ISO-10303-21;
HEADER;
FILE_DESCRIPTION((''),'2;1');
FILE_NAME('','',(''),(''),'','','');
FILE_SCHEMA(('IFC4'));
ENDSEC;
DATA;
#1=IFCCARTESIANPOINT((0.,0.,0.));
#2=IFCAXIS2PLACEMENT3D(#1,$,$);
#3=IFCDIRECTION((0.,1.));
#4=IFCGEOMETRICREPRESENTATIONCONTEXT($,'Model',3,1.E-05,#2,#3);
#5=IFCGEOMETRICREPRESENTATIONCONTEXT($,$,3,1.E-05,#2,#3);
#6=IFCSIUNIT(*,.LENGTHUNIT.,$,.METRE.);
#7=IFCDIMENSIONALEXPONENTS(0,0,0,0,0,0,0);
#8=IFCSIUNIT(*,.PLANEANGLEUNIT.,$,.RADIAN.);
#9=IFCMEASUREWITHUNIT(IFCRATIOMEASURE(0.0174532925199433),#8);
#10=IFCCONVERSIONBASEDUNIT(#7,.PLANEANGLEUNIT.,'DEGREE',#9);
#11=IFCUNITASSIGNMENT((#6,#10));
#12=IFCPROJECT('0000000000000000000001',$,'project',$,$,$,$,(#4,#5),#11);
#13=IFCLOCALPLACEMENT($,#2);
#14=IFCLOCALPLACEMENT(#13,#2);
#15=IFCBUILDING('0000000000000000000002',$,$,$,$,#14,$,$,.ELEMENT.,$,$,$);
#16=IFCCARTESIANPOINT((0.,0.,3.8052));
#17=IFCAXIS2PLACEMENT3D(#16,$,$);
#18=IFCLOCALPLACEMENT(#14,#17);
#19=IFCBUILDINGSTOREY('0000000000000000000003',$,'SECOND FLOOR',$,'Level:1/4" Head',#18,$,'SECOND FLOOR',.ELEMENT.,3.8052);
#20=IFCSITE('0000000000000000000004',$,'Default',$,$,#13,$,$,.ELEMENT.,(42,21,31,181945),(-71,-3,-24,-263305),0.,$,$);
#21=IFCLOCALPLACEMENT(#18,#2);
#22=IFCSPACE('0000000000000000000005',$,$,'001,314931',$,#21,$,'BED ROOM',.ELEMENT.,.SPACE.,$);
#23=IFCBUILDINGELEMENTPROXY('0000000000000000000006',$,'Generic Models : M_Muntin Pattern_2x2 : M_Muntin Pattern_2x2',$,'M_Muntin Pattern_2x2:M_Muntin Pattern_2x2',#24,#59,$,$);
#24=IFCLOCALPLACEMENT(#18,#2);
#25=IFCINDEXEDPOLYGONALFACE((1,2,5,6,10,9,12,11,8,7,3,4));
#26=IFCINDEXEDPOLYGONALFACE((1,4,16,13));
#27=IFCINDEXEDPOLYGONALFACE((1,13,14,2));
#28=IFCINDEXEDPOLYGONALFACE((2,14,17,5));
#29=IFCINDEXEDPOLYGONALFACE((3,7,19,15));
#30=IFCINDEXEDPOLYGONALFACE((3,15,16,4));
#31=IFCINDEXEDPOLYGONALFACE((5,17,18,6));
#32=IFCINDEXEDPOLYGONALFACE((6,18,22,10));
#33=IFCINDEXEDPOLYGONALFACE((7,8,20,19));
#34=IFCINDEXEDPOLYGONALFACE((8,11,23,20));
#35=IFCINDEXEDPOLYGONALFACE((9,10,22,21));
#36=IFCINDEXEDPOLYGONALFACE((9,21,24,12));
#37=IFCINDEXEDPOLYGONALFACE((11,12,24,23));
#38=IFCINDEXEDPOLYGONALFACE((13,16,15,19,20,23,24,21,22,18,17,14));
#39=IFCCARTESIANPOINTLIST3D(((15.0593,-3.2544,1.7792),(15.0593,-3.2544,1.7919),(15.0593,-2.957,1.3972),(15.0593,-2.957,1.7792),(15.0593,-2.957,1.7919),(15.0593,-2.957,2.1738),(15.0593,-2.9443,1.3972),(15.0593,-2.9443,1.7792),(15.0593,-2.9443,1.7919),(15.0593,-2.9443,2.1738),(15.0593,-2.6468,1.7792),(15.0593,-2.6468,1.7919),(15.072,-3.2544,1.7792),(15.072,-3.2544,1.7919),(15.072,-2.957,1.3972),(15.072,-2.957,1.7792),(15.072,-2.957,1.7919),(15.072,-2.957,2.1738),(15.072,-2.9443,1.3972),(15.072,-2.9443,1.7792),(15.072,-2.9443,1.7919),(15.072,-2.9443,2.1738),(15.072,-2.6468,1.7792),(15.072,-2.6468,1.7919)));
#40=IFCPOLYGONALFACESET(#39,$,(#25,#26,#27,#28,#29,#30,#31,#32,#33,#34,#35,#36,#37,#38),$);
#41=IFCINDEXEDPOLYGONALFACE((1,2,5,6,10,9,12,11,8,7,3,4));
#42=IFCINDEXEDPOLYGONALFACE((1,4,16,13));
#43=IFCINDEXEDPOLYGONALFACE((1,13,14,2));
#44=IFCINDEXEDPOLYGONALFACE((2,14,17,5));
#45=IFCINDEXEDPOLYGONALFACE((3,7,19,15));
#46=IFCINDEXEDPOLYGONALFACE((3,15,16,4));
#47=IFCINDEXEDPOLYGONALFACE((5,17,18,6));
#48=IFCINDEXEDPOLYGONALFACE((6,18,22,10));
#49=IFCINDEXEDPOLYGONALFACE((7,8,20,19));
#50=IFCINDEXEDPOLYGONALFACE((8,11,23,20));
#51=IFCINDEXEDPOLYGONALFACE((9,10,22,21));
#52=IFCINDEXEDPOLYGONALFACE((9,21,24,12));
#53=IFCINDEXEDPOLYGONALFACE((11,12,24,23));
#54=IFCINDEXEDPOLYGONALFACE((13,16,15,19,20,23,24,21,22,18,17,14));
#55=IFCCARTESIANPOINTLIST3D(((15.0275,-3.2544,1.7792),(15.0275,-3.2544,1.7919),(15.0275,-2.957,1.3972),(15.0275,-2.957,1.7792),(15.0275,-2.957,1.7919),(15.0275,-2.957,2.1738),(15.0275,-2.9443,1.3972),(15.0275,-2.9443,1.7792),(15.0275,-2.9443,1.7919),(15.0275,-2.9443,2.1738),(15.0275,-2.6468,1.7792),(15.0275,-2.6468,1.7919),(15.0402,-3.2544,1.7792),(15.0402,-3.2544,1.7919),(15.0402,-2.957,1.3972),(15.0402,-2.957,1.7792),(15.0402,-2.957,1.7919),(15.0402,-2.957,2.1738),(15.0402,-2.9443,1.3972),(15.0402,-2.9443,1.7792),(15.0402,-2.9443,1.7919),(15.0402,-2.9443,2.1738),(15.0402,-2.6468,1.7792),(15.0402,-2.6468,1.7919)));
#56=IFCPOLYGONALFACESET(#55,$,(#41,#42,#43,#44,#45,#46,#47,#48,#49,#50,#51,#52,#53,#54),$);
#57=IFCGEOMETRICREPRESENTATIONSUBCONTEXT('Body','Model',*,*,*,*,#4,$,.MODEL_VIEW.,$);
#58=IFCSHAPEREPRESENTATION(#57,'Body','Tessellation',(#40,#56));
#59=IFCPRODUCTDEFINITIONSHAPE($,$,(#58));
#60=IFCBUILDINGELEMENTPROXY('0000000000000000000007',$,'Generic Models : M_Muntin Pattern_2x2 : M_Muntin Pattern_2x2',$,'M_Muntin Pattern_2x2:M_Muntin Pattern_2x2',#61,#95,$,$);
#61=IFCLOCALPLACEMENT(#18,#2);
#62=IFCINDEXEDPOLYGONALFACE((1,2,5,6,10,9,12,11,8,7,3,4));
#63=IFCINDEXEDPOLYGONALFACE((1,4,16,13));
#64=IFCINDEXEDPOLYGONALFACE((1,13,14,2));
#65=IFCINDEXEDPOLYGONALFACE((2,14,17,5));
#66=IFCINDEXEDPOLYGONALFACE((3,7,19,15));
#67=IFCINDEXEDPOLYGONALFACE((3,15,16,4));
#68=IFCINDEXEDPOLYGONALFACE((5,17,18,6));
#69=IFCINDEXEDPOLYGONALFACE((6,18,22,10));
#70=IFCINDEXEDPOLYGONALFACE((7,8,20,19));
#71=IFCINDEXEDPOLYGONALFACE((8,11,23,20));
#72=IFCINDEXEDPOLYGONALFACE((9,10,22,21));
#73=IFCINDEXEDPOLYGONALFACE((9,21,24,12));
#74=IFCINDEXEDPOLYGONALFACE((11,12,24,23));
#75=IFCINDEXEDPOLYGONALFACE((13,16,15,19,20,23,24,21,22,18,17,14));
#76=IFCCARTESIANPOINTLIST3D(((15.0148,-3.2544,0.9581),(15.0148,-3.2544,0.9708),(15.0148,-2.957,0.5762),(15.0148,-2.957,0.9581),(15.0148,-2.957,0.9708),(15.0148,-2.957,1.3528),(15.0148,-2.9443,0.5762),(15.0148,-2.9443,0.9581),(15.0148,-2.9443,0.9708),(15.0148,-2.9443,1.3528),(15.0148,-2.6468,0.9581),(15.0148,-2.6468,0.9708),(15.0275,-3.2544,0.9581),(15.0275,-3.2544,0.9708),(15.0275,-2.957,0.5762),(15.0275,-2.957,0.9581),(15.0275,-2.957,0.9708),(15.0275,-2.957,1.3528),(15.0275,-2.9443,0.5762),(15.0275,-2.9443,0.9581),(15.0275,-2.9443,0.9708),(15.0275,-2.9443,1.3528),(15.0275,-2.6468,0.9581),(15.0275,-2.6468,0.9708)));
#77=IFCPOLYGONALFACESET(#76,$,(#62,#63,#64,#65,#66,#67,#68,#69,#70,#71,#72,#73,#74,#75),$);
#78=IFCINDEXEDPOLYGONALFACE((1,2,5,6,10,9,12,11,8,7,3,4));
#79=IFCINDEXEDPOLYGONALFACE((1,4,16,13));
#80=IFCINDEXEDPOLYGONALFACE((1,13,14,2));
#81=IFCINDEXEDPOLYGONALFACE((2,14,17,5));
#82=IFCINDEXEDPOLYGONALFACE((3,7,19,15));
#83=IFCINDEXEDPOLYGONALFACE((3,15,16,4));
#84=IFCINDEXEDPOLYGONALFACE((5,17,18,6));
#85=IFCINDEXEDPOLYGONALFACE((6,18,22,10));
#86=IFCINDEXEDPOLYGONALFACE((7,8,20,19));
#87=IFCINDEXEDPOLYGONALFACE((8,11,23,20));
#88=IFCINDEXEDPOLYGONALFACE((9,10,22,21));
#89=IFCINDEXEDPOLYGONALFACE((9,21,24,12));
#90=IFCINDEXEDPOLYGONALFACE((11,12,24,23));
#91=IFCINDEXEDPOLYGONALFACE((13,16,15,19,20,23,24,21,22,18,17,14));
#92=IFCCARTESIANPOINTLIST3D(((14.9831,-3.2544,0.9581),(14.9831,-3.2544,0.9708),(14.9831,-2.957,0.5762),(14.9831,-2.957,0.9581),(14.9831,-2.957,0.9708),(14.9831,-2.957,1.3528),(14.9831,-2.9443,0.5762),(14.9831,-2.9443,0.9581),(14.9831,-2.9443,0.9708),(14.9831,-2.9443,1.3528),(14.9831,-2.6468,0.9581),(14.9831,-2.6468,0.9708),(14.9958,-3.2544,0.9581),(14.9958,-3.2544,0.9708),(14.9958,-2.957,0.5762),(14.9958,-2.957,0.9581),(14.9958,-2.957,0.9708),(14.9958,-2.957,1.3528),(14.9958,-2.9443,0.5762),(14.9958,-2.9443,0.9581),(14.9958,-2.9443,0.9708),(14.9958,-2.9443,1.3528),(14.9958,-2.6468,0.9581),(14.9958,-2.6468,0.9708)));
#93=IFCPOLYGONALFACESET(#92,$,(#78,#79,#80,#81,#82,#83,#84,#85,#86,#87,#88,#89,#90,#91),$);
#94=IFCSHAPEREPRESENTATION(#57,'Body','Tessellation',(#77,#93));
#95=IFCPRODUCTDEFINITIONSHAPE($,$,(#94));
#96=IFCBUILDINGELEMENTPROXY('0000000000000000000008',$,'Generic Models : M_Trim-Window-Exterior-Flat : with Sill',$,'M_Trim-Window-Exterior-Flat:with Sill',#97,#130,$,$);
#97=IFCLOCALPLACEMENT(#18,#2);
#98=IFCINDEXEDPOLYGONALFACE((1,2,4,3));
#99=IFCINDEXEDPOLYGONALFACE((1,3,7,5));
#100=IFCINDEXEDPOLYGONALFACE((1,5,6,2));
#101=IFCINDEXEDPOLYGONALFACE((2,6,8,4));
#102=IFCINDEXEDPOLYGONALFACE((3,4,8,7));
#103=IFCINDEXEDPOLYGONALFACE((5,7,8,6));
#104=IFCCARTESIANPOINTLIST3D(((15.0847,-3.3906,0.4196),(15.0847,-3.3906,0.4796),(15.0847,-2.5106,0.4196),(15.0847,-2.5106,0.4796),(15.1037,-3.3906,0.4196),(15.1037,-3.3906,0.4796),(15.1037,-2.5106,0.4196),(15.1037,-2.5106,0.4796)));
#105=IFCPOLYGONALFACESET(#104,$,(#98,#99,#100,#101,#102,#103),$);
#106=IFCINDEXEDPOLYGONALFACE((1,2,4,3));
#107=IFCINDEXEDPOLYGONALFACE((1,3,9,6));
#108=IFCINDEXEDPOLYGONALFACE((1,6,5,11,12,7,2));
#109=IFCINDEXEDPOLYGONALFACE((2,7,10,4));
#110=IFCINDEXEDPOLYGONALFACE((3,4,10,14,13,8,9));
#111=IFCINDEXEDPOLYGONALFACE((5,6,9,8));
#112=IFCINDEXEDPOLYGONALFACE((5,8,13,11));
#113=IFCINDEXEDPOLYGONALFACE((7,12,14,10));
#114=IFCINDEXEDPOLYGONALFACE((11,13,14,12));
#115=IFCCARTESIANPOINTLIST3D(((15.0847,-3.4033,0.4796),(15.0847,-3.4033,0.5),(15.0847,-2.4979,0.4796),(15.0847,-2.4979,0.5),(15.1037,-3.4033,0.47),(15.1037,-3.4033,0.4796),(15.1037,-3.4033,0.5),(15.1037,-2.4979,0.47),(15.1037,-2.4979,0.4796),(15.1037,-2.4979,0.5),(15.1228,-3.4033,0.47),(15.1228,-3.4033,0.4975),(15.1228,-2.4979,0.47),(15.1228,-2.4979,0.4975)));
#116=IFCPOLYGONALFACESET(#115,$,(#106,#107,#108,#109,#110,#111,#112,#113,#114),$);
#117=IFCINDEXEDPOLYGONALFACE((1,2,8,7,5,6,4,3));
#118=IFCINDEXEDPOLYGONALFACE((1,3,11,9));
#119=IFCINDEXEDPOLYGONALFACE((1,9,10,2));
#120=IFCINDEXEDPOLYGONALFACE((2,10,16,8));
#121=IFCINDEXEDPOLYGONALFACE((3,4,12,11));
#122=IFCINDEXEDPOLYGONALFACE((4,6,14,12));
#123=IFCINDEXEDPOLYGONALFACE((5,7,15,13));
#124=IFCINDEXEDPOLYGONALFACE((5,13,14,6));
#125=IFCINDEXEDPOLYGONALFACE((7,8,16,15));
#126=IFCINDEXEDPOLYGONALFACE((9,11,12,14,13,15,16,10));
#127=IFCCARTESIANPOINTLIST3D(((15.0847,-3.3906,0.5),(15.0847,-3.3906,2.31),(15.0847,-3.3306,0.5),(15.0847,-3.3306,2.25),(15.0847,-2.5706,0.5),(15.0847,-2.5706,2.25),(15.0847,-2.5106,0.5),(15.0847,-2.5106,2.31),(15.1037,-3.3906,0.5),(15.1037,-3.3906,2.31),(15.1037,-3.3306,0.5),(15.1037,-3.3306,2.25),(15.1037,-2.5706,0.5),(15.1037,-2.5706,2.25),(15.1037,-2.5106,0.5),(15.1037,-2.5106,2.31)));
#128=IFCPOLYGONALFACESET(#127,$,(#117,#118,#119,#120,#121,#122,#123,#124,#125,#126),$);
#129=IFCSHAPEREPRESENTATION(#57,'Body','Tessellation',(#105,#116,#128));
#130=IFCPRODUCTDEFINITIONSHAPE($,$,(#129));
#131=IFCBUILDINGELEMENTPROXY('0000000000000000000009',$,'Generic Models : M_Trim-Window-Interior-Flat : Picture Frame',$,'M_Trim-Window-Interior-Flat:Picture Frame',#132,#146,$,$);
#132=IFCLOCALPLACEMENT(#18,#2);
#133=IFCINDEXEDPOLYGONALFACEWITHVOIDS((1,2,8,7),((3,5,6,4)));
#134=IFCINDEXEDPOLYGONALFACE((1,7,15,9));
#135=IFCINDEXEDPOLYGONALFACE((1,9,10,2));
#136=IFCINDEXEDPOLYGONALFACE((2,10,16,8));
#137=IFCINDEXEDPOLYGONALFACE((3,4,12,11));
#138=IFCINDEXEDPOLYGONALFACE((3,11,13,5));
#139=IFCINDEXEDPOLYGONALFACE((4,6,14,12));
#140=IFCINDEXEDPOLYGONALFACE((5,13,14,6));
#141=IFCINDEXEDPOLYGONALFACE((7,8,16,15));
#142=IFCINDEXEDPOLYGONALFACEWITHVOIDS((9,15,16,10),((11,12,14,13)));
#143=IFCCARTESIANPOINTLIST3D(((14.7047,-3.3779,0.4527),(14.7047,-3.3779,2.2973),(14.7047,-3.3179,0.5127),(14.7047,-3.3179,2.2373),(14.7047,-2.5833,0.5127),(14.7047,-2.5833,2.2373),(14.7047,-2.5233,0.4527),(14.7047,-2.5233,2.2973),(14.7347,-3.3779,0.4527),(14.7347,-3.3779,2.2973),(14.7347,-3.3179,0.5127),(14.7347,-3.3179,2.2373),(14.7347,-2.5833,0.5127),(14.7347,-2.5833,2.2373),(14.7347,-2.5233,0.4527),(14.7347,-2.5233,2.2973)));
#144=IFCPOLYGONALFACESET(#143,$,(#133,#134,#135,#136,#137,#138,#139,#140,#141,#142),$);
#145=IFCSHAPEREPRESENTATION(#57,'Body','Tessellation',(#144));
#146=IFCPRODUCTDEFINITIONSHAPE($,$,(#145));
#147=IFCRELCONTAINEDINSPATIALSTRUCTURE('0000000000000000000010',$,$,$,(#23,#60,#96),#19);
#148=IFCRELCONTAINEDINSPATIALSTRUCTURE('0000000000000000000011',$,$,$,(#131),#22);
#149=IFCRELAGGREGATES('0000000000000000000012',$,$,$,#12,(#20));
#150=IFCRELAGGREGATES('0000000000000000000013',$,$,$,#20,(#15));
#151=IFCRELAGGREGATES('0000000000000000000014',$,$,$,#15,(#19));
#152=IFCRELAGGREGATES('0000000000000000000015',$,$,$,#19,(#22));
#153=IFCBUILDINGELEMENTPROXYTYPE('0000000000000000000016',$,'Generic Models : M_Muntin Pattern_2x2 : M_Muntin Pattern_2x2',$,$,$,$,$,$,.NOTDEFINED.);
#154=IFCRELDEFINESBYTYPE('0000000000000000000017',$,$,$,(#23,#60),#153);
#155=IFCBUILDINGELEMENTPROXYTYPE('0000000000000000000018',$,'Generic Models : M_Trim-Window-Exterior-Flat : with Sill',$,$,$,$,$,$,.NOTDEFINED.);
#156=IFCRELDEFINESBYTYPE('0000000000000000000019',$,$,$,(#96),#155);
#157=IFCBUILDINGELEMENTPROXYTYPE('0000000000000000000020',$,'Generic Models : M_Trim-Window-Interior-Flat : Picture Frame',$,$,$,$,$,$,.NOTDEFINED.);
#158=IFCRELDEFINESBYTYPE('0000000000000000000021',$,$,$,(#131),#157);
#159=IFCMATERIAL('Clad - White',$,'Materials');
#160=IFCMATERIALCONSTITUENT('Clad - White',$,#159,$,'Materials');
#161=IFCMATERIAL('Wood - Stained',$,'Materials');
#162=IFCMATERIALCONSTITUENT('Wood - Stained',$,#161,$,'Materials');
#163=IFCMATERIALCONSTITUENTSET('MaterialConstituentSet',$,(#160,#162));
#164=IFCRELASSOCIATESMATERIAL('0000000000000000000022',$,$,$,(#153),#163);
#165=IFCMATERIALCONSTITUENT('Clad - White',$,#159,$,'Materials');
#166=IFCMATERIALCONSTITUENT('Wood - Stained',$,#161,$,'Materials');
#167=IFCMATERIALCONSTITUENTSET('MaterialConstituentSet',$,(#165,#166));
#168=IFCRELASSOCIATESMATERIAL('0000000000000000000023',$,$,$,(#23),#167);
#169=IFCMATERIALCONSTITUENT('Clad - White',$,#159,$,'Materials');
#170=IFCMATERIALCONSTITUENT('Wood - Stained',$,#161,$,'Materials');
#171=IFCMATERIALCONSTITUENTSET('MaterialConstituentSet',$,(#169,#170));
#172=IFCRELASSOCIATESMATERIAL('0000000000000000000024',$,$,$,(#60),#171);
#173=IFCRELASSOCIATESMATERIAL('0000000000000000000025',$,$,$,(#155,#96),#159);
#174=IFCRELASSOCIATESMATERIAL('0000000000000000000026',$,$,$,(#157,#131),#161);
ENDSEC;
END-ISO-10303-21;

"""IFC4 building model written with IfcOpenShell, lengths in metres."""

from ifc_helpers import new_model, entity, si_unit, converted_unit, direction, frame, frame_2d, origin, place, context, subcontext, project, spatial, polyline, rectangle, outline, extrude, source, transform, mapped, material, constituent, constituent_set, type_object, type_shapes, element, save


model = new_model("IFC4")

# Units and contexts
model_context = context("Model", 3, precision=1e-05, world=origin(), true_north=direction((0.0, 1.0)))
context_of_model = context(None, 3, precision=1e-05, world=origin(), true_north=direction((0.0, 1.0)))
body_context = subcontext(model_context, "Body", "Model", "MODEL_VIEW")
ifc_project = project(units=[si_unit("LENGTHUNIT", "METRE"), converted_unit("PLANEANGLEUNIT", "DEGREE", entity("IfcRatioMeasure", 0.0174532925199433), si_unit("PLANEANGLEUNIT", "RADIAN"), dimensions=[0, 0, 0, 0, 0, 0, 0])], contexts=[model_context, context_of_model])

# Site, building, storey
site_placement = place(None, origin())
site = spatial("IfcSite", under=ifc_project, at=site_placement, Name="Default", CompositionType="ELEMENT", RefLatitude=(42, 21, 31, 181945), RefLongitude=(-71, -3, -24, -263305), RefElevation=0.0)
building_placement = place(site_placement, origin())
building = spatial("IfcBuilding", under=site, at=building_placement, CompositionType="ELEMENT")
storey_placement = place(building_placement, frame((0.0, 0.0, 3.8052)))
storey = spatial("IfcBuildingStorey", under=building, at=storey_placement, Name="SECOND FLOOR", ObjectType="Level:1/4\" Head", LongName="SECOND FLOOR", CompositionType="ELEMENT", Elevation=3.8052)

# Shared definitions
ifc_material_1 = material(Name="Wood - Stained", Category="Materials")

# Shared definitions
ifc_material_2 = material(Name="Clad - White", Category="Materials")

# Shared definitions
space_1_placement = place(storey_placement, origin())
space_1 = spatial("IfcSpace", under=storey, at=space_1_placement, Description="001,314931", LongName="BED ROOM", CompositionType="ELEMENT", PredefinedType="SPACE")

# Building element proxies
ifc_constituent_1 = constituent(ifc_material_2, Name="Clad - White", Category="Materials")
ifc_constituent_2 = constituent(ifc_material_1, Name="Wood - Stained", Category="Materials")
ifc_constituent_set_1 = constituent_set(constituents=[ifc_constituent_1, ifc_constituent_2], Name="MaterialConstituentSet")
ifc_constituent_3 = constituent(ifc_material_2, Name="Clad - White", Category="Materials")
ifc_constituent_4 = constituent(ifc_material_1, Name="Wood - Stained", Category="Materials")
ifc_constituent_set_2 = constituent_set(constituents=[ifc_constituent_3, ifc_constituent_4], Name="MaterialConstituentSet")
building_element_proxy_type_1 = type_object("IfcBuildingElementProxyType", Name="Generic Models : M_Muntin Pattern_2x2 : M_Muntin Pattern_2x2", PredefinedType="NOTDEFINED", material=ifc_constituent_set_2)
shared_shape_1 = source(origin(), body_context, "Body", "SweptSolid", [
    extrude(outline(polyline([(0.0064, -0.0064), (0.3883, -0.0064), (0.3883, 0.0063), (0.0064, 0.0063), (0.0064, 0.3038), (-0.0063, 0.3038), (-0.0063, 0.0063), (-0.3883, 0.0063), (-0.3883, -0.0064), (-0.0063, -0.0064), (-0.0063, -0.3038), (0.0064, -0.3038), (0.0064, -0.0064)])), frame((0.0, -0.0222, 0.3883), z_axis=(0.0, 1.0, 0.0), x_axis=(0.0, 0.0, 1.0)), (0.0, 0.0, 1.0), 0.0127),
    extrude(outline(polyline([(0.0064, -0.0064), (0.3883, -0.0064), (0.3883, 0.0063), (0.0064, 0.0063), (0.0064, 0.3038), (-0.0063, 0.3038), (-0.0063, 0.0063), (-0.3883, 0.0063), (-0.3883, -0.0064), (-0.0063, -0.0064), (-0.0063, -0.3038), (0.0064, -0.3038), (0.0064, -0.0064)])), frame((0.0, 0.0095, 0.3883), z_axis=(0.0, 1.0, 0.0), x_axis=(0.0, 0.0, 1.0)), (0.0, 0.0, 1.0), 0.0127),
])
type_shapes(building_element_proxy_type_1, [shared_shape_1])
proxy_1_placement = place(storey_placement, frame((15.0498, -2.9506, 1.3972), z_axis=(0.0, 0.0, 1.0), x_axis=(0.0, 1.0, 0.0)))
element("IfcBuildingElementProxy", 1, at=proxy_1_placement, inside=storey, type_object=building_element_proxy_type_1, material=ifc_constituent_set_1, Name="Generic Models : M_Muntin Pattern_2x2 : M_Muntin Pattern_2x2", ObjectType="M_Muntin Pattern_2x2:M_Muntin Pattern_2x2", context=body_context, shape_type="MappedRepresentation", body=[
    mapped(shared_shape_1, transform((0.0, 0.0, 0.0), scale=1.0)),
])
ifc_constituent_5 = constituent(ifc_material_2, Name="Clad - White", Category="Materials")
ifc_constituent_6 = constituent(ifc_material_1, Name="Wood - Stained", Category="Materials")
ifc_constituent_set_3 = constituent_set(constituents=[ifc_constituent_5, ifc_constituent_6], Name="MaterialConstituentSet")
proxy_2_placement = place(storey_placement, frame((15.0053, -2.9506, 0.5762), z_axis=(0.0, 0.0, 1.0), x_axis=(0.0, 1.0, 0.0)))
element("IfcBuildingElementProxy", 2, at=proxy_2_placement, inside=storey, type_object=building_element_proxy_type_1, material=ifc_constituent_set_3, Name="Generic Models : M_Muntin Pattern_2x2 : M_Muntin Pattern_2x2", ObjectType="M_Muntin Pattern_2x2:M_Muntin Pattern_2x2", context=body_context, shape_type="MappedRepresentation", body=[
    mapped(shared_shape_1, transform((0.0, 0.0, 0.0), scale=1.0)),
])
building_element_proxy_type_2 = type_object("IfcBuildingElementProxyType", Name="Generic Models : M_Trim-Window-Exterior-Flat : with Sill", PredefinedType="NOTDEFINED", material=ifc_material_2)
shared_shape_2 = source(origin(), body_context, "Body", "SweptSolid", [
    extrude(rectangle(XDim=0.06, YDim=0.88, at=frame_2d((0.0, 0.0), x_axis=(1.0, 0.0))), frame((0.0, 1.8004, 0.0), z_axis=(0.0, 0.0, 1.0), x_axis=(0.0, 1.0, 0.0)), (0.0, 0.0, 1.0), 0.0191),
    extrude(outline(polyline([(-0.0152, -0.019), (0.0123, -0.019), (0.0148, 0.0), (0.0148, 0.019), (-0.0057, 0.019), (-0.0057, 0.0), (-0.0152, 0.0), (-0.0152, -0.019)])), frame((-0.4527, 1.7648, 0.019), z_axis=(1.0, 0.0, 0.0), x_axis=(0.0, -1.0, 0.0)), (0.0, 0.0, 1.0), 0.9054),
    extrude(outline(polyline([(-0.44, -0.92), (0.44, -0.92), (0.44, 0.89), (0.38, 0.89), (0.38, -0.86), (-0.38, -0.86), (-0.38, 0.89), (-0.44, 0.89), (-0.44, -0.92)])), frame((0.0, 0.86, 0.0)), (0.0, 0.0, 1.0), 0.0191),
])
type_shapes(building_element_proxy_type_2, [shared_shape_2])
proxy_3_placement = place(storey_placement, frame((15.0847, -2.9506, 2.25), z_axis=(1.0, 0.0, 0.0), x_axis=(0.0, -1.0, 0.0)))
element("IfcBuildingElementProxy", 3, at=proxy_3_placement, inside=storey, type_object=building_element_proxy_type_2, material=ifc_material_2, Name="Generic Models : M_Trim-Window-Exterior-Flat : with Sill", ObjectType="M_Trim-Window-Exterior-Flat:with Sill", context=body_context, shape_type="MappedRepresentation", body=[
    mapped(shared_shape_2, transform((0.0, 0.0, 0.0), scale=1.0)),
])
building_element_proxy_type_3 = type_object("IfcBuildingElementProxyType", Name="Generic Models : M_Trim-Window-Interior-Flat : Picture Frame", PredefinedType="NOTDEFINED", material=ifc_material_1)
shared_shape_3 = source(origin(), body_context, "Body", "SweptSolid", [
    extrude(outline(polyline([(-0.9223, -0.4273), (0.9223, -0.4273), (0.9223, 0.4273), (-0.9223, 0.4273), (-0.9223, -0.4273)]), holes=[polyline([(-0.8623, -0.3673), (-0.8623, 0.3673), (0.8623, 0.3673), (0.8623, -0.3673), (-0.8623, -0.3673)])]), frame((0.0, 0.875, 0.0), z_axis=(0.0, 0.0, 1.0), x_axis=(0.0, 1.0, 0.0)), (0.0, 0.0, 1.0), 0.03),
])
type_shapes(building_element_proxy_type_3, [shared_shape_3])
proxy_4_placement = place(space_1_placement, frame((14.7347, -2.9506, 2.25), z_axis=(-1.0, 0.0, 0.0), x_axis=(0.0, 1.0, 0.0)))
element("IfcBuildingElementProxy", 4, at=proxy_4_placement, inside=space_1, type_object=building_element_proxy_type_3, material=ifc_material_1, Name="Generic Models : M_Trim-Window-Interior-Flat : Picture Frame", ObjectType="M_Trim-Window-Interior-Flat:Picture Frame", context=body_context, shape_type="MappedRepresentation", body=[
    mapped(shared_shape_3, transform((0.0, 0.0, 0.0), scale=1.0)),
])

save(model, "model.ifc")
